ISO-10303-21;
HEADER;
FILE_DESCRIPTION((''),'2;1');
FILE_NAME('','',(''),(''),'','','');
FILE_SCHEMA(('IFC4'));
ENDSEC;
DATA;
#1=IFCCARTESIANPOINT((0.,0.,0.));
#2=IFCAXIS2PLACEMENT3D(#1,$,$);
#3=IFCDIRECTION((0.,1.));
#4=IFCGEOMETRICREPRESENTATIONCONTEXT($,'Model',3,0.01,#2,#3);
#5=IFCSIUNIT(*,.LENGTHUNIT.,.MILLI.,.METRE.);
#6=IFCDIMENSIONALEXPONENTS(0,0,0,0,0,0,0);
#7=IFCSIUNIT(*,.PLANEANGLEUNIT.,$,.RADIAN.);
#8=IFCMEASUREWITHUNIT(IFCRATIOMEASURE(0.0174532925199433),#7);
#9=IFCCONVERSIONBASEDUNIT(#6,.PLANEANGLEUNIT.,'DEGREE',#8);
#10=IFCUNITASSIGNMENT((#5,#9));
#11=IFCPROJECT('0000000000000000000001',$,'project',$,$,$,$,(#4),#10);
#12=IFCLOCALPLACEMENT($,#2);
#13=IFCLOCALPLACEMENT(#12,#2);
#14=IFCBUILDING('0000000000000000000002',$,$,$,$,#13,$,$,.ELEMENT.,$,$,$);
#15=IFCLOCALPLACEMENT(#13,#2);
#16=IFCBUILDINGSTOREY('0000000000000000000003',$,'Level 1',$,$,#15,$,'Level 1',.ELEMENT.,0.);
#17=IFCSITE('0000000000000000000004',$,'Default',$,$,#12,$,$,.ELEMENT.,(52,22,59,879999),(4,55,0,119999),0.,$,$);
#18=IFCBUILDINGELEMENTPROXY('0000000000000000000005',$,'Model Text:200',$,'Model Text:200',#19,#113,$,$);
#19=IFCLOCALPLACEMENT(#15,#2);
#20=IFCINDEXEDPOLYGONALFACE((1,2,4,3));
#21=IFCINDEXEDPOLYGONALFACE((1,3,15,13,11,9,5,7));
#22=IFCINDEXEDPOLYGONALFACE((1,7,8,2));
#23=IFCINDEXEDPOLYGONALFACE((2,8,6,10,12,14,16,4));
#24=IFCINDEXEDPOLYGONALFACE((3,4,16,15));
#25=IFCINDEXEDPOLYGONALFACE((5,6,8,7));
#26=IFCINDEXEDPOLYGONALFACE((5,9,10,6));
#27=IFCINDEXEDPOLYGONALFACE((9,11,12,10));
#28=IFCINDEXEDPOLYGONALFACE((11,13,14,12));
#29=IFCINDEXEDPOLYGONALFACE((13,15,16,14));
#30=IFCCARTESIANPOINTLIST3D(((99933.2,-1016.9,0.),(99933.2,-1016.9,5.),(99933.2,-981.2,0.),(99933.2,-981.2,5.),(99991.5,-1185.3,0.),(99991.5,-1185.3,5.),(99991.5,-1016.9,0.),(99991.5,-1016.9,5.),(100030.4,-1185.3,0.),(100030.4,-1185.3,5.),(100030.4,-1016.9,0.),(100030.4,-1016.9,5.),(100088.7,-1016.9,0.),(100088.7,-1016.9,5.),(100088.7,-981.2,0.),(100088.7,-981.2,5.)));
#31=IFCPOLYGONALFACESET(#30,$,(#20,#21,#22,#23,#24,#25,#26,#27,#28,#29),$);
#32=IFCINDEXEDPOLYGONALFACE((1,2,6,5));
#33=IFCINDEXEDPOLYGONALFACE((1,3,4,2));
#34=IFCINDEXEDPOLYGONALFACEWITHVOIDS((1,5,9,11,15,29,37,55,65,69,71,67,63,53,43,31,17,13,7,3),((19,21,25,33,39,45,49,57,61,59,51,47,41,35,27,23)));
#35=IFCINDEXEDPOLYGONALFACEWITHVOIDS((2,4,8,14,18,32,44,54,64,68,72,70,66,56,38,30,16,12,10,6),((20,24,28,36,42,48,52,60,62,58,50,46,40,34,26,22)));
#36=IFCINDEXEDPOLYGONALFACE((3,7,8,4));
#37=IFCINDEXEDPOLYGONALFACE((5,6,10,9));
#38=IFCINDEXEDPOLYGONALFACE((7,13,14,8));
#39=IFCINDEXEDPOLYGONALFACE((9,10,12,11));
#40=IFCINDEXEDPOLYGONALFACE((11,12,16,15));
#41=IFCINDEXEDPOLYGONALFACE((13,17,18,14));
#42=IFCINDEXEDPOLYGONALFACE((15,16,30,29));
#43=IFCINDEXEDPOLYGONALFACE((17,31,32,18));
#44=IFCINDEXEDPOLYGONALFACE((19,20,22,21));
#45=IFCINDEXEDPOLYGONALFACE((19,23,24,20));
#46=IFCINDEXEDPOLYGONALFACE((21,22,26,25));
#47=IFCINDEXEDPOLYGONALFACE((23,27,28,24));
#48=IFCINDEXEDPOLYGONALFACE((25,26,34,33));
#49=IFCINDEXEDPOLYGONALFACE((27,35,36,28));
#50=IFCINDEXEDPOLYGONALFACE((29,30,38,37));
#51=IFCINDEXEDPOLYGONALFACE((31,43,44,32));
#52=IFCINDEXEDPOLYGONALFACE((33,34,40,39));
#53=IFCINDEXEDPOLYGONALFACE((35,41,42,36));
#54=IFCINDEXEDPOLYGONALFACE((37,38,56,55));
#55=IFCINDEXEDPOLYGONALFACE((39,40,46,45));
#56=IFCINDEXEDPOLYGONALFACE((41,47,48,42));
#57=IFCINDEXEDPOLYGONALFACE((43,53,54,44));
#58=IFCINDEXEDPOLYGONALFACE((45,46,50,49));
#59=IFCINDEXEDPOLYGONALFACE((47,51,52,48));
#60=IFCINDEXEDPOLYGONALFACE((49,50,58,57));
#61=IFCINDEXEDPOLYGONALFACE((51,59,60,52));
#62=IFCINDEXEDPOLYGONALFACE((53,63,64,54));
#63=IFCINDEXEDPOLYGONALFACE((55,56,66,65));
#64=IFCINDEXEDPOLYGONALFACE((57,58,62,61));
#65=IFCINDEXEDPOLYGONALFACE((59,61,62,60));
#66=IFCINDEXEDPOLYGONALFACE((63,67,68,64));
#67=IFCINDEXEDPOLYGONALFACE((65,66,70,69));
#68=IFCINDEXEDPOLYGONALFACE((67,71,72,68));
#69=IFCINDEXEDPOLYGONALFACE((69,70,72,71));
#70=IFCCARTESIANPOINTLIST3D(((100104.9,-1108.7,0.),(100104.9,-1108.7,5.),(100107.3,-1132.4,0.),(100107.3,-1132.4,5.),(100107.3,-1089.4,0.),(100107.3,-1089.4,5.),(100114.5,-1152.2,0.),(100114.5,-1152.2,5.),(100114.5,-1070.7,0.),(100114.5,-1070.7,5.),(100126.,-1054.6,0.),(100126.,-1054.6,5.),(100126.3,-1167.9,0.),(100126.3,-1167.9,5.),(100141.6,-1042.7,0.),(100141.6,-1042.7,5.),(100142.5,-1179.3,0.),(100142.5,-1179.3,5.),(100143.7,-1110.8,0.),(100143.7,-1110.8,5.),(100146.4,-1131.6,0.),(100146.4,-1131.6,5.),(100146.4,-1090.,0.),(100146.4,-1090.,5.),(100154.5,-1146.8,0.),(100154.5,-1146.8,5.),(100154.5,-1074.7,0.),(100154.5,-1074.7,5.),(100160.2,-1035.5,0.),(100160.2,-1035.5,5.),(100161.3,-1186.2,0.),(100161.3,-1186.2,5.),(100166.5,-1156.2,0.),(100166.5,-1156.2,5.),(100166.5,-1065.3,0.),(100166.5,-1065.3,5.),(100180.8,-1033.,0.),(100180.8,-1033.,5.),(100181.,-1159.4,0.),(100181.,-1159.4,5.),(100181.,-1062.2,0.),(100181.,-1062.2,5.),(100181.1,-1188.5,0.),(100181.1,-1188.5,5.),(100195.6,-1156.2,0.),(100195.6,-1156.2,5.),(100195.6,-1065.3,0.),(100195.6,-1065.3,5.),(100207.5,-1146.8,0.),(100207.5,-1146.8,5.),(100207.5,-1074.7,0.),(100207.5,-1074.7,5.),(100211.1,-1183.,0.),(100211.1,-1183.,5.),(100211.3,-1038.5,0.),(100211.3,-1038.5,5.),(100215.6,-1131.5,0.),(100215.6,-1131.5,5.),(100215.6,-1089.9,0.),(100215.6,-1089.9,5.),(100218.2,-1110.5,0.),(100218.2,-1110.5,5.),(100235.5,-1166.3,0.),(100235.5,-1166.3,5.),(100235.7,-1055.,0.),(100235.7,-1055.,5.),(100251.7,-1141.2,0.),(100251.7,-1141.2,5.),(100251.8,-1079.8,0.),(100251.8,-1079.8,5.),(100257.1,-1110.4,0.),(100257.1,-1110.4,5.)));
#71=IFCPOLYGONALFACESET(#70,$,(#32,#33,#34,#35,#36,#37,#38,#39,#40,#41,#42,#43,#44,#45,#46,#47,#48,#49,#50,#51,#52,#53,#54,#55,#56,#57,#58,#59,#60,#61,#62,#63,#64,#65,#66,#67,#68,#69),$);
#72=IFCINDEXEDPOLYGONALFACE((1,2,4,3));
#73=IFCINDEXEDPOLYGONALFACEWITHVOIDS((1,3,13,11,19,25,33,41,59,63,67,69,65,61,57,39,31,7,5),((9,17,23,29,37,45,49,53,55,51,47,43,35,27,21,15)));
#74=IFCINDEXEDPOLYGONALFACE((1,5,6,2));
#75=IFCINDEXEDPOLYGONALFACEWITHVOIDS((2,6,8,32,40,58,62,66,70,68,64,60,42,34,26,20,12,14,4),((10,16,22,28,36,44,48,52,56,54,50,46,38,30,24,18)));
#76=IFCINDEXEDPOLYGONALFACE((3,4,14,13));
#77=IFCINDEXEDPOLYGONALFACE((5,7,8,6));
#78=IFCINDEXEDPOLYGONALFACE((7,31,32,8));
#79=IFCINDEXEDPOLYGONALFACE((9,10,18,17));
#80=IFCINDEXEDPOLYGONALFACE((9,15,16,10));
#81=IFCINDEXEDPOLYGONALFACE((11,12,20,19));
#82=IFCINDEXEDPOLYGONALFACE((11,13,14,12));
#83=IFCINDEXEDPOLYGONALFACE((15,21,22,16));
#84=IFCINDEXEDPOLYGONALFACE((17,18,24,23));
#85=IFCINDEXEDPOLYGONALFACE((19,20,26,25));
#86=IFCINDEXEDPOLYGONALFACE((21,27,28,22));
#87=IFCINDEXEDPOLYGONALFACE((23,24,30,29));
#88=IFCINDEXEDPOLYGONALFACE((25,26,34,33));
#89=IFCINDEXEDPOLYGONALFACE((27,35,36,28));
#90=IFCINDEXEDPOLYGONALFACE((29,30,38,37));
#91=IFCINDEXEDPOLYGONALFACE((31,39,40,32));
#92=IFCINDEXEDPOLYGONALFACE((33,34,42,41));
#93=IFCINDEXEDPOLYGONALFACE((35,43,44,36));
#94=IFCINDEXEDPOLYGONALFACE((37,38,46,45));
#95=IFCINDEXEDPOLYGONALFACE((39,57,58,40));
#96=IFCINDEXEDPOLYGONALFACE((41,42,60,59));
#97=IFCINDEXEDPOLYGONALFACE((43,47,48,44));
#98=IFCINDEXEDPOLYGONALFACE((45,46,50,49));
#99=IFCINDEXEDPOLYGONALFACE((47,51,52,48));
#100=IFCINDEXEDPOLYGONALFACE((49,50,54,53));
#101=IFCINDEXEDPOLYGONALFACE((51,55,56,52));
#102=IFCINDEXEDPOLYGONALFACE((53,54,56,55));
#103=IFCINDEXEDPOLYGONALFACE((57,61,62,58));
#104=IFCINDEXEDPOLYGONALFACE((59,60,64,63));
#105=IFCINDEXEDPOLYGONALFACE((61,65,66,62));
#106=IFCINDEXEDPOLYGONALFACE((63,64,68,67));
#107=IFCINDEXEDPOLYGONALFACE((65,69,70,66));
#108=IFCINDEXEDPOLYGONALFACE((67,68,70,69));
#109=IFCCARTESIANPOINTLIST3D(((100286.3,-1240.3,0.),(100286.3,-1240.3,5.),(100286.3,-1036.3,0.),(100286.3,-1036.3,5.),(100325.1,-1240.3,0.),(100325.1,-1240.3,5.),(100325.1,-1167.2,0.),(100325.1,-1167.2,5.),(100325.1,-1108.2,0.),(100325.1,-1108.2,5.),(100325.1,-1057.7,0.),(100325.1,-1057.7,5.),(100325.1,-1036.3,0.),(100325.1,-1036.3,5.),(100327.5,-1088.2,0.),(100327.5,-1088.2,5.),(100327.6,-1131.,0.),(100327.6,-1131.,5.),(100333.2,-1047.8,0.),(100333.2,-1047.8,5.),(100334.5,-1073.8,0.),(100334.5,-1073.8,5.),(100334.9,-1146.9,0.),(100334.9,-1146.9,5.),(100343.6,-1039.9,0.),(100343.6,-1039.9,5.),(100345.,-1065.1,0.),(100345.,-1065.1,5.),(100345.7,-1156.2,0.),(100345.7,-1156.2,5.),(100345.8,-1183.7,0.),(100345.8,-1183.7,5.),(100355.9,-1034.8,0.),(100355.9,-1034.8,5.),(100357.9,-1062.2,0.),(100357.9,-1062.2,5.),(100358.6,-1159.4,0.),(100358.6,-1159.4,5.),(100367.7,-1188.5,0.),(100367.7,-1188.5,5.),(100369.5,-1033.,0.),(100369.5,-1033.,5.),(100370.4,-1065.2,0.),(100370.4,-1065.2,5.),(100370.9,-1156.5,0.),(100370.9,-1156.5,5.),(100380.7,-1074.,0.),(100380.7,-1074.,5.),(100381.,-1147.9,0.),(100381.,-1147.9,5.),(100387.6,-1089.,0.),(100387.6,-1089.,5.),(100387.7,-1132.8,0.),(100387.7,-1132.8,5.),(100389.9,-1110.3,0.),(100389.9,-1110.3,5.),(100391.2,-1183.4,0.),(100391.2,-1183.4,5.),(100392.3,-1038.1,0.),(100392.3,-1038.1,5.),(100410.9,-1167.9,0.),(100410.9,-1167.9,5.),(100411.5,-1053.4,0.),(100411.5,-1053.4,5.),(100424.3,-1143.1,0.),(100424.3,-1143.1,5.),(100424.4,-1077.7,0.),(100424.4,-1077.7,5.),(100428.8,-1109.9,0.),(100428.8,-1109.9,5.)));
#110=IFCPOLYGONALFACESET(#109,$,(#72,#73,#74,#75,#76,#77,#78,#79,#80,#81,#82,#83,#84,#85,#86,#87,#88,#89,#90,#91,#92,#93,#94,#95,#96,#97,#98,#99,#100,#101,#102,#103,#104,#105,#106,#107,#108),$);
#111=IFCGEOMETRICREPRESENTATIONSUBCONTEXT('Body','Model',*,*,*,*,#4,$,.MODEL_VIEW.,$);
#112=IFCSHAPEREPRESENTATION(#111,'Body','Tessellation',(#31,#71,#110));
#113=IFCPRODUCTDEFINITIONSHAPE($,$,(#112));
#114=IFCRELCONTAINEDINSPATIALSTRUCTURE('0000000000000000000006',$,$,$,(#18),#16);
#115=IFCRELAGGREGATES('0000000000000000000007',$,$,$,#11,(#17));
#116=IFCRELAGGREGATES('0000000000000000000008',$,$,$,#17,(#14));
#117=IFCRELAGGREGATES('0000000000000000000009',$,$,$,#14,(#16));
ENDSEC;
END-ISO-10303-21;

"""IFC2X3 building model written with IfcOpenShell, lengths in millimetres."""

from ifc_helpers import new_model, entity, si_unit, converted_unit, direction, frame, origin, place, context, subcontext, project, spatial, polyline, outline, extrude, element, save


model = new_model("IFC2X3")

# Units and contexts
model_context = context("Model", 3, precision=0.01, world=origin(), true_north=direction((0.0, 1.0)))
body_context = subcontext(model_context, "Body", "Model", "MODEL_VIEW")
ifc_project = project(units=[si_unit("LENGTHUNIT", "METRE", prefix="MILLI"), converted_unit("PLANEANGLEUNIT", "DEGREE", entity("IfcRatioMeasure", 0.0174532925199433), si_unit("PLANEANGLEUNIT", "RADIAN"), dimensions=[0, 0, 0, 0, 0, 0, 0])], contexts=[model_context])

# Site, building, storey
site_placement = place(None, origin())
site = spatial("IfcSite", under=ifc_project, at=site_placement, Name="Default", CompositionType="ELEMENT", RefLatitude=(52, 22, 59, 879999), RefLongitude=(4, 55, 0, 119999), RefElevation=0.0)
building_placement = place(site_placement, origin())
building = spatial("IfcBuilding", under=site, at=building_placement, CompositionType="ELEMENT")
storey_placement = place(building_placement, origin())
storey = spatial("IfcBuildingStorey", under=building, at=storey_placement, Name="Level 1", LongName="Level 1", CompositionType="ELEMENT", Elevation=0.0)

# Building element proxy
proxy_1_placement = place(building_placement, origin())
element("IfcBuildingElementProxy", 1, at=proxy_1_placement, inside=storey, Name="Model Text:200", ObjectType="Model Text:200", context=body_context, shape_type="SweptSolid", body=[
    extrude(outline(polyline([(-19.4, -135.2), (19.4, -135.2), (19.4, 33.2), (77.7, 33.2), (77.7, 68.8), (-77.7, 68.8), (-77.7, 33.2), (-19.4, 33.2), (-19.4, -135.2)])), frame((100010.9, -1050.1, 0.0)), (0.0, 0.0, 1.0), 5.0),
    extrude(outline(polyline([(-8.8, -65.7), (15.1, -65.7), (35.5, -60.5), (52.3, -50.4), (65.3, -35.4), (74.1, -17.3), (78.4, 2.1), (75.9, 32.5), (61.8, 58.5), (38.4, 77.1), (8.3, 85.6), (-22.7, 83.3), (-49.0, 69.9), (-67.8, 47.3), (-76.3, 17.5), (-76.0, -3.3), (-70.7, -22.5), (-60.5, -39.2), (-45.5, -52.3), (-27.7, -61.4), (-8.8, -65.7)]), holes=[polyline([(-2.7, -27.2), (-23.1, -22.5), (-37.5, -12.9), (-45.7, 0.0), (-47.3, 14.8), (-42.7, 28.9), (-32.2, 39.9), (-16.3, 46.3), (4.5, 46.9), (25.1, 42.1), (39.6, 32.6), (47.7, 19.7), (49.4, 5.0), (44.8, -9.2), (34.2, -20.2), (18.2, -26.7), (-2.7, -27.2)])]), frame((100171.1, -1110.8, 0.0), z_axis=(0.0, 0.0, 1.0), x_axis=(0.100608, -0.994926, 0.0)), (0.0, 0.0, 1.0), 5.0),
    extrude(outline(polyline([(-73.1, -75.4), (130.9, -75.4), (130.9, -36.6), (57.8, -36.6), (74.3, -15.9), (79.1, 6.0), (73.9, 29.5), (58.4, 49.2), (33.6, 62.6), (0.5, 67.1), (-31.8, 62.8), (-56.1, 49.8), (-71.3, 30.7), (-76.4, 7.8), (-74.7, -5.8), (-69.6, -18.1), (-61.7, -28.5), (-51.7, -36.6), (-73.1, -36.6), (-73.1, -75.4)]), holes=[polyline([(-1.2, -36.6), (-21.2, -34.2), (-35.6, -27.2), (-44.3, -16.7), (-47.2, -3.8), (-44.3, 8.7), (-35.4, 19.0), (-20.4, 25.9), (0.8, 28.2), (23.3, 26.0), (38.5, 19.3), (47.1, 9.2), (49.9, -3.1), (46.8, -16.0), (37.4, -26.8), (21.5, -34.1), (-1.2, -36.6)])]), frame((100361.7, -1109.4, 0.0), z_axis=(0.0, 0.0, 1.0), x_axis=(0.0, -1.0, 0.0)), (0.0, 0.0, 1.0), 5.0),
])

save(model, "model.ifc")
